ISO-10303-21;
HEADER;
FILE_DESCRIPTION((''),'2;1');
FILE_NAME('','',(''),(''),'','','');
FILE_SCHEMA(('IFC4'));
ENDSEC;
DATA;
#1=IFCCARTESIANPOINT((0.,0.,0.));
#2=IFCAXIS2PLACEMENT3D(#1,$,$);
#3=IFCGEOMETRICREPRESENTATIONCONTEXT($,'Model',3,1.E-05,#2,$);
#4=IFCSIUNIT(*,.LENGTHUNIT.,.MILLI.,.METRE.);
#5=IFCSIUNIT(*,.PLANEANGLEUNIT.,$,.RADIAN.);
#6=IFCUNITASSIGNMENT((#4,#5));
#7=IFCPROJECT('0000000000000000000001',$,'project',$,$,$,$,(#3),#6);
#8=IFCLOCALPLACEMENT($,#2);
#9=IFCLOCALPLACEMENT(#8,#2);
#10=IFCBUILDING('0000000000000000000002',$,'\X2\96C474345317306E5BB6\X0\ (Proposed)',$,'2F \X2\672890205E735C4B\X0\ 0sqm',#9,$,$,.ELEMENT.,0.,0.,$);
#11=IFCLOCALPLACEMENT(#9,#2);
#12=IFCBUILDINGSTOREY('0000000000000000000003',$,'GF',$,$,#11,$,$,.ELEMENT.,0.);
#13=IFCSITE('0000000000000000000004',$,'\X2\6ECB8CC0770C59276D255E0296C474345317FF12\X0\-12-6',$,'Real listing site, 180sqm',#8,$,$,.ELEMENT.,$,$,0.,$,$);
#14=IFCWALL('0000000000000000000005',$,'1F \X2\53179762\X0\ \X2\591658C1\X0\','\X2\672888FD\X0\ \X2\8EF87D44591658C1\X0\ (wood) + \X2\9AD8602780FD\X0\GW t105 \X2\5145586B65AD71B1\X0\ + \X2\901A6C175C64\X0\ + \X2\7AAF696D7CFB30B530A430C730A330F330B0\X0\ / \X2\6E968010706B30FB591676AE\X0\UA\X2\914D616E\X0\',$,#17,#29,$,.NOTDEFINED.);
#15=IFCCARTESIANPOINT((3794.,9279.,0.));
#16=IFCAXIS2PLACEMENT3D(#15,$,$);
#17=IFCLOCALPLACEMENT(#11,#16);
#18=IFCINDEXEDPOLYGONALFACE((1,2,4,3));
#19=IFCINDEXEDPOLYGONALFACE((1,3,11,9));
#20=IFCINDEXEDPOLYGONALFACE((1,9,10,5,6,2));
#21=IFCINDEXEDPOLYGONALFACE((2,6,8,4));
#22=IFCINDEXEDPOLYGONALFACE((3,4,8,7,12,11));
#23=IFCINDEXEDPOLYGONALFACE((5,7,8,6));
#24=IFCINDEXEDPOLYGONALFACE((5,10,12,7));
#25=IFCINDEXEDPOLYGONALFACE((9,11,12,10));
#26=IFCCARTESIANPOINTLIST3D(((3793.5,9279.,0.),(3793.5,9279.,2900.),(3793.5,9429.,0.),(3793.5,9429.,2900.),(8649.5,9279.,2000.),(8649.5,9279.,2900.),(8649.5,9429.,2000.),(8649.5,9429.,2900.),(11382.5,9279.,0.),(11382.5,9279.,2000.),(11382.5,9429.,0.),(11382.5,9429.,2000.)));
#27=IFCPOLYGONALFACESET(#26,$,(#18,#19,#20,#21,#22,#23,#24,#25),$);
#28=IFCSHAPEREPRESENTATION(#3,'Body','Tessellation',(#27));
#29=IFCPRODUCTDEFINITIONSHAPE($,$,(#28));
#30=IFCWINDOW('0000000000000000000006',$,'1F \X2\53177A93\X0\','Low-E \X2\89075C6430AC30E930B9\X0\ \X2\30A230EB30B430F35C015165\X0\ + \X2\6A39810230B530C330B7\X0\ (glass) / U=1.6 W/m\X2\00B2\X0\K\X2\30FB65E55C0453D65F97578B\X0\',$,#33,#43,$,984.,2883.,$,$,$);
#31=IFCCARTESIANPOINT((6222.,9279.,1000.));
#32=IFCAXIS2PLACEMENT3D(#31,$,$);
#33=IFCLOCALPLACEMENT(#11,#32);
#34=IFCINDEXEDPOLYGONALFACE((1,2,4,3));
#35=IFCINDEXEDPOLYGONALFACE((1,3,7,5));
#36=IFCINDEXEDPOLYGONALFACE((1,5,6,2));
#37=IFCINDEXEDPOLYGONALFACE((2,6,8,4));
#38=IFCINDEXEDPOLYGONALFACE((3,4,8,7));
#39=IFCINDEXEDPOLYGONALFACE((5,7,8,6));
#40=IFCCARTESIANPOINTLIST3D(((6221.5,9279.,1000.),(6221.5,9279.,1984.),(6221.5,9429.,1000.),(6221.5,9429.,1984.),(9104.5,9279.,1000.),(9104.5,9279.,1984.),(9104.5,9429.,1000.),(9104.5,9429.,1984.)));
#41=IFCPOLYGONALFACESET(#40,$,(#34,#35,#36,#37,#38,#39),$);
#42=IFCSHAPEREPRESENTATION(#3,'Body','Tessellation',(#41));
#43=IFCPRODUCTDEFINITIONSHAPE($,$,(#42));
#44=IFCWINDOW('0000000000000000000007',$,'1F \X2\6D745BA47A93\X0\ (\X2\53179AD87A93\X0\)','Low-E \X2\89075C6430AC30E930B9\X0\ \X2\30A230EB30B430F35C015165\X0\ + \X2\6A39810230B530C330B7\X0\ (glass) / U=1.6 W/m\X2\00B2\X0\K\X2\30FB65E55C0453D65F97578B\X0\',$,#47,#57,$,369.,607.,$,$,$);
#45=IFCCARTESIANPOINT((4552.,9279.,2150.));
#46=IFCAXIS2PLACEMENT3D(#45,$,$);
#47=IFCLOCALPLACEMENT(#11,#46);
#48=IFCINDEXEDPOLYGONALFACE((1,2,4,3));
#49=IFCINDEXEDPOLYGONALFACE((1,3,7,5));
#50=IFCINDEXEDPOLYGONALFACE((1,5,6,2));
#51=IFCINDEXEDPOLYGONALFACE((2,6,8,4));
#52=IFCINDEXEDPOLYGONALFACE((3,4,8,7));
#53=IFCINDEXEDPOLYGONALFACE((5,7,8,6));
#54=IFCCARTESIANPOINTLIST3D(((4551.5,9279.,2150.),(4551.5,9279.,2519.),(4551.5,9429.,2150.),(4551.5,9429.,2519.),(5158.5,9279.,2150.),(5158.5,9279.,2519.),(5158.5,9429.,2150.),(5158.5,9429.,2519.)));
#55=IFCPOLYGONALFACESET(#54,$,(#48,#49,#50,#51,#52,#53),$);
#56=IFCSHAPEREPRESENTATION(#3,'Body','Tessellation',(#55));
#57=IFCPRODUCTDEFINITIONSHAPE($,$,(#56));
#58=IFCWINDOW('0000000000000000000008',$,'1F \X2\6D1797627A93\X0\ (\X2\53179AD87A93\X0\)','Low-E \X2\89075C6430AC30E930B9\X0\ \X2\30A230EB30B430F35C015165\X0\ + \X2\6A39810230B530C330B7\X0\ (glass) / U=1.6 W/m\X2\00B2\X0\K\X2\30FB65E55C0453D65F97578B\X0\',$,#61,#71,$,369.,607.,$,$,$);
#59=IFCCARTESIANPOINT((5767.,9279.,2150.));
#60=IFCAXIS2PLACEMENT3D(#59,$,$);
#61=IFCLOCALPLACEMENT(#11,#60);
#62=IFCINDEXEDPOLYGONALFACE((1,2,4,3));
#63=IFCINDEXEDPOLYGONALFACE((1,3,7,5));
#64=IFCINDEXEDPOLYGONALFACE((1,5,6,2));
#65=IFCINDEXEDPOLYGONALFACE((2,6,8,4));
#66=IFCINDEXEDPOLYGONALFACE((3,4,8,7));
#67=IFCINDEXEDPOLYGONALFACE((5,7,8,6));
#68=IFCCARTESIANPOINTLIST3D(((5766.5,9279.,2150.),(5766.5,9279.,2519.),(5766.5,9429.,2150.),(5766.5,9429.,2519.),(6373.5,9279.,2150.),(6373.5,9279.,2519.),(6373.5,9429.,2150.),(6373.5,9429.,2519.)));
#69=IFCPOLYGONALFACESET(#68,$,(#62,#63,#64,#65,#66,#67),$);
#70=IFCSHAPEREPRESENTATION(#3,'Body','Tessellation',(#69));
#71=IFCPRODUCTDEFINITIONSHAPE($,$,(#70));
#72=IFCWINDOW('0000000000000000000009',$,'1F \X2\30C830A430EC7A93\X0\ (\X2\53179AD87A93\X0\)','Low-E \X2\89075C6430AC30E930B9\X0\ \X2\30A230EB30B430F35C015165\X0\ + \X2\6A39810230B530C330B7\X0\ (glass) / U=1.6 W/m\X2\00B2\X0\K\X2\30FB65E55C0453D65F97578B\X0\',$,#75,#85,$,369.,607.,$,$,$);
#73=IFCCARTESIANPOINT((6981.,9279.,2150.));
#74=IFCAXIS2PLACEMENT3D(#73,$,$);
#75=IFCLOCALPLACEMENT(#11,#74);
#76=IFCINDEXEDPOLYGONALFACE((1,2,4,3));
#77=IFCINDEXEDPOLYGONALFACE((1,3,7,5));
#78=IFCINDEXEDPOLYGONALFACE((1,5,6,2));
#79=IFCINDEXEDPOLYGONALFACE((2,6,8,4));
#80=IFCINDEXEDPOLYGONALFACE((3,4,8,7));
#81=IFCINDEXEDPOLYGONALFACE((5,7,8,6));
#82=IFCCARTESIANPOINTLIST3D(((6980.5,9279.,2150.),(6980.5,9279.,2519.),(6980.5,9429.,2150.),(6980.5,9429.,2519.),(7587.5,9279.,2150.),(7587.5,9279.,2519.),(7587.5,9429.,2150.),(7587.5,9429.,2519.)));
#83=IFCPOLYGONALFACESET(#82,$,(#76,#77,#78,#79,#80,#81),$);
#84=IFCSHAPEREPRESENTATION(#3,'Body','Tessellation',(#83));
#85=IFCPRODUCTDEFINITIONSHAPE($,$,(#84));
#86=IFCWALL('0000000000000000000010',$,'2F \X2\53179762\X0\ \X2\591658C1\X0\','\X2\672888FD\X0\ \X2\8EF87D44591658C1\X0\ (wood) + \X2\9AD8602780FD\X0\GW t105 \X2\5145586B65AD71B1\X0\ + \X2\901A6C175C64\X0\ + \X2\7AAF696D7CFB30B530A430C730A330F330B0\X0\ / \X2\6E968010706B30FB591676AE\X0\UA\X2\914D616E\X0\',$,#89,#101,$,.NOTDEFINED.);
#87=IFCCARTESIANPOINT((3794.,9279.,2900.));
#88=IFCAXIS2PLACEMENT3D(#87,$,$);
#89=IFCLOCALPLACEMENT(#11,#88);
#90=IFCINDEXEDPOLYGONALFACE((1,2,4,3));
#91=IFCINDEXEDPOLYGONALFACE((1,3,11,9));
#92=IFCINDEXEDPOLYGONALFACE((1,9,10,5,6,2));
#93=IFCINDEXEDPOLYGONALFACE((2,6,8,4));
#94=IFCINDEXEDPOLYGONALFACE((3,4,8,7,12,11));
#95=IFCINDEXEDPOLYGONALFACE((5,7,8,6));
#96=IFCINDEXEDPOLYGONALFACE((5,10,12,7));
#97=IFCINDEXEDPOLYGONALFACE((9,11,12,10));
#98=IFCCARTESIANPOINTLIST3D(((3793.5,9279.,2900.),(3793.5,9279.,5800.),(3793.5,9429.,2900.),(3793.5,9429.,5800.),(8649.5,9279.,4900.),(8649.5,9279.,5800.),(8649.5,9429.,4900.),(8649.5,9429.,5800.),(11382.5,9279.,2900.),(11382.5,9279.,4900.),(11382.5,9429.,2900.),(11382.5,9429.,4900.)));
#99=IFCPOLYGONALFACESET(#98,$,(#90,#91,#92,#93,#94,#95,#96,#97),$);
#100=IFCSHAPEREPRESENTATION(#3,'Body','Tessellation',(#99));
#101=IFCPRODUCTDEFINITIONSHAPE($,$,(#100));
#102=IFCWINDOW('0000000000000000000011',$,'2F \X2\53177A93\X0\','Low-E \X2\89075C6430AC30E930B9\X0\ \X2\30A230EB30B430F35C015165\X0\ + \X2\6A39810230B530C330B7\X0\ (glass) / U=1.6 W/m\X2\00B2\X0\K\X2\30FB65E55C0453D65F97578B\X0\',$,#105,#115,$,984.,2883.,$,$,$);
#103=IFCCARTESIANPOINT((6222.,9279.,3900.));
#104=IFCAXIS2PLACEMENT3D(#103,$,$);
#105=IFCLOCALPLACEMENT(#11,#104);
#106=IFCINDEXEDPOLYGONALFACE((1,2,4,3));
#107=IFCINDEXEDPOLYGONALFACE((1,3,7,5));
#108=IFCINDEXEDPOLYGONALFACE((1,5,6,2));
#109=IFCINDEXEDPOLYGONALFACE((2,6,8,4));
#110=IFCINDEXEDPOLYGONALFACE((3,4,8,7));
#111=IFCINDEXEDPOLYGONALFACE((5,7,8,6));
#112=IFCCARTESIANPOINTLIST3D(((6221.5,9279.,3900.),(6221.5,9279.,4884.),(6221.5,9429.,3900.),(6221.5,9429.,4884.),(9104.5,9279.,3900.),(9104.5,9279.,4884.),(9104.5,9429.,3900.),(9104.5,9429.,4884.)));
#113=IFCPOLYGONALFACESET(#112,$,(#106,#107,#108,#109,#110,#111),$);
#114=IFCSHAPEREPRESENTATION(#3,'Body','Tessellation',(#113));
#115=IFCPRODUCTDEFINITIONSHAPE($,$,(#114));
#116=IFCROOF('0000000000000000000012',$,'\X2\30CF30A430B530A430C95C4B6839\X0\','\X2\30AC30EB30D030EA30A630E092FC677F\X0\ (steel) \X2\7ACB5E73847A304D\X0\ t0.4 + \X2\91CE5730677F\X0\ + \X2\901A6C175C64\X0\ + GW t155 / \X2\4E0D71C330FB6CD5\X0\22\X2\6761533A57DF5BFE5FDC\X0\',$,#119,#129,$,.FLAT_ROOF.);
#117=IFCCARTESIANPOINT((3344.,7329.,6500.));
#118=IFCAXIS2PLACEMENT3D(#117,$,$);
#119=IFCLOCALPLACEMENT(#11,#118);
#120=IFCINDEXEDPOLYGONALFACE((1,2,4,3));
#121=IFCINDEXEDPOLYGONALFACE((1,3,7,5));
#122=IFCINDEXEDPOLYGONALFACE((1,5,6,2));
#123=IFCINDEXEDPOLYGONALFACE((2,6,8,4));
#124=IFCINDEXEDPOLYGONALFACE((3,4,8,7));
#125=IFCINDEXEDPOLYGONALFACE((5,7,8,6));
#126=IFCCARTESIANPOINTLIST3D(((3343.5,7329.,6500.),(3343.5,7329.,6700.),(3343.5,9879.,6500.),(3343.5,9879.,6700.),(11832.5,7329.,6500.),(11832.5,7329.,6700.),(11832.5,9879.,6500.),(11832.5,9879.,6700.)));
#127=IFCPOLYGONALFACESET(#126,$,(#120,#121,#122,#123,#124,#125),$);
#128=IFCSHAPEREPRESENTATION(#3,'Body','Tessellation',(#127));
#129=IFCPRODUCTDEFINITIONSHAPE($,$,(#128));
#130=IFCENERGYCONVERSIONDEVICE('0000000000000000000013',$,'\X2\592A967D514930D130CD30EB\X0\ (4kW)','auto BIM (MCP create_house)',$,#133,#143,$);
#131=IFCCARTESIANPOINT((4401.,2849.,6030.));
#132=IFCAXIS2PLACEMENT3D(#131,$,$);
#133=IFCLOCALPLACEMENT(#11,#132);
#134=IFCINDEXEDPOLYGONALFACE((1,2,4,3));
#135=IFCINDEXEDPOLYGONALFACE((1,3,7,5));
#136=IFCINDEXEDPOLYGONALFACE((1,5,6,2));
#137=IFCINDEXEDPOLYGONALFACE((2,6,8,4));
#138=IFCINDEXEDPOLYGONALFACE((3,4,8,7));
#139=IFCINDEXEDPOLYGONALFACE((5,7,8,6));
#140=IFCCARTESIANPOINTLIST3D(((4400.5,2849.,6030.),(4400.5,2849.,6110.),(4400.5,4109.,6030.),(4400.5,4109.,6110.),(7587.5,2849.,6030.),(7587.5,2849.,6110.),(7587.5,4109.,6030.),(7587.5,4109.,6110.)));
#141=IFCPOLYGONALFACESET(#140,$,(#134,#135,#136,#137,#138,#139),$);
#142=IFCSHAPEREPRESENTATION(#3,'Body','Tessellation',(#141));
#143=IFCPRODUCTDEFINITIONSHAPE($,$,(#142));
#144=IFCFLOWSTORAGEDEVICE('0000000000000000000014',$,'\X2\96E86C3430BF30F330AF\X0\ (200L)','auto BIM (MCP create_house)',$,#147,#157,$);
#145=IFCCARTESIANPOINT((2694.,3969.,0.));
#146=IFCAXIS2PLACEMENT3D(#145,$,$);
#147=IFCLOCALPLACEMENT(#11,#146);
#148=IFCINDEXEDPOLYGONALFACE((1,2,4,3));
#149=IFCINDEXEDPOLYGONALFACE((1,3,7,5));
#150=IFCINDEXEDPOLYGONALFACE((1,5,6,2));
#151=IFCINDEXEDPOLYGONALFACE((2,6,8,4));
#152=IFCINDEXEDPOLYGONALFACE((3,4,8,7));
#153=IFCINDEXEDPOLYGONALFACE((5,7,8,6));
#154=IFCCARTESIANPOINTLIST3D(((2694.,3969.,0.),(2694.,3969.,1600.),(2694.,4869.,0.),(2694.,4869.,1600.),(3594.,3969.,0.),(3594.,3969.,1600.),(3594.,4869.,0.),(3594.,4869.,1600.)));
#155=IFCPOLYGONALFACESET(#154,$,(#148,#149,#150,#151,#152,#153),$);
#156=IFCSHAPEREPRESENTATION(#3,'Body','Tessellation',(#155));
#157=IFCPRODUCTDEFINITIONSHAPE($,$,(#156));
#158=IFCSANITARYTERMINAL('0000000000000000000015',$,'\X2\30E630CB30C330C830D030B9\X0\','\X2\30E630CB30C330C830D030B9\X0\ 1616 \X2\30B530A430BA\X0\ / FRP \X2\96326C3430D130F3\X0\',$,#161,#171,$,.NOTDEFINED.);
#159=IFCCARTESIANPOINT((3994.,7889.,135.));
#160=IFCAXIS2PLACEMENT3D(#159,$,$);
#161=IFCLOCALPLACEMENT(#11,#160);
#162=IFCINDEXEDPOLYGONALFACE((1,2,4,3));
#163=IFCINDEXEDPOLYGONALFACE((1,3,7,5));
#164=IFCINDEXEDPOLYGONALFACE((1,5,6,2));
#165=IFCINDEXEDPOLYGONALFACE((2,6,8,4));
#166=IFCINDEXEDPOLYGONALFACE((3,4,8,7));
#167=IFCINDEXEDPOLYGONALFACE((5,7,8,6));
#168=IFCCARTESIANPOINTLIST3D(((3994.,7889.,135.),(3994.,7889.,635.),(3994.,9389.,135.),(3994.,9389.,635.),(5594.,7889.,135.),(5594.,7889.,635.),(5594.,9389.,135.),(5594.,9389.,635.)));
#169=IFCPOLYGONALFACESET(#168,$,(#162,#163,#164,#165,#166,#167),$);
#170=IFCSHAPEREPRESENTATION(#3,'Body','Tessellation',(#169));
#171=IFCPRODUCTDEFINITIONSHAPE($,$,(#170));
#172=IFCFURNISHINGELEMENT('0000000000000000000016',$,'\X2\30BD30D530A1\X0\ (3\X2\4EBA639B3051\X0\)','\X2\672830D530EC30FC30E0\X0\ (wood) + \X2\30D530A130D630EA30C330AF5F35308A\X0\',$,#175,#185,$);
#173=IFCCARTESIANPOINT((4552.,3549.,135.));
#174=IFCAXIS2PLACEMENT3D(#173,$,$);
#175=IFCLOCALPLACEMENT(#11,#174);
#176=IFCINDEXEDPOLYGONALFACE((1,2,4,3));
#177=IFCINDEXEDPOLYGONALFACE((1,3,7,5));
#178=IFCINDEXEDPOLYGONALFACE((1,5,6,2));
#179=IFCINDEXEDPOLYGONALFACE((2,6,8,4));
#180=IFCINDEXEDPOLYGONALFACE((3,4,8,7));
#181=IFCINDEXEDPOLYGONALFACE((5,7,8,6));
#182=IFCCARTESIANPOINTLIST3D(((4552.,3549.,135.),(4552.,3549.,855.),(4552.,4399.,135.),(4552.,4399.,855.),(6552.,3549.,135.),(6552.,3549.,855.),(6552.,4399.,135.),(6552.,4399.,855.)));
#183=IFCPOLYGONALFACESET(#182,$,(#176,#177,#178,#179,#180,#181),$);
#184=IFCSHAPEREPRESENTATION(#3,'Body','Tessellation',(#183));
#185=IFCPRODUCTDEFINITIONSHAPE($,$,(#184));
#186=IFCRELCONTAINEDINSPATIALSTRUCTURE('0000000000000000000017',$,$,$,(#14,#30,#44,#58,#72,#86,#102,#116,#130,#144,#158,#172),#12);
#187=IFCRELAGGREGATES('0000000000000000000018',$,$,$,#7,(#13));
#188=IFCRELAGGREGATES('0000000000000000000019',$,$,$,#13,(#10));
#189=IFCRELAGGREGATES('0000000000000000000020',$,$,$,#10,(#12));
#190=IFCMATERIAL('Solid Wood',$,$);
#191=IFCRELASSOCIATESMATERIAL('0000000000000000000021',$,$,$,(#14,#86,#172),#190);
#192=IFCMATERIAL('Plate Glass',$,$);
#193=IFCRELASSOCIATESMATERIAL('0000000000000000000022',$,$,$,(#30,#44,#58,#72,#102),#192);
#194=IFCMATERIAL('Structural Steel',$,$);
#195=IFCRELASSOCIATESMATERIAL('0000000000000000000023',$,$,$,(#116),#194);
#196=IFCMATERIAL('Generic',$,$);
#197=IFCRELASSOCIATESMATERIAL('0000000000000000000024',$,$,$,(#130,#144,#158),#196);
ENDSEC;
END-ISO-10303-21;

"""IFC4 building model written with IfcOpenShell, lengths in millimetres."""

from ifc_helpers import new_model, si_unit, frame, frame_2d, origin, place, context, project, spatial, rectangle, extrude, material, element, fill, save


model = new_model("IFC4")

# Units and contexts
model_context = context("Model", 3, precision=1e-05, world=origin())
ifc_project = project(units=[si_unit("LENGTHUNIT", "METRE", prefix="MILLI"), si_unit("PLANEANGLEUNIT", "RADIAN")], contexts=[model_context])

# Site, building, storey
site_placement = place(None, origin())
site = spatial("IfcSite", under=ifc_project, at=site_placement, Name="滋賀県大津市雄琴北２-12-6", ObjectType="Real listing site, 180sqm", CompositionType="ELEMENT", RefElevation=0.0)
building_placement = place(site_placement, origin())
building = spatial("IfcBuilding", under=site, at=building_placement, Name="雄琴北の家 (Proposed)", ObjectType="2F 木造平屋 0sqm", CompositionType="ELEMENT", ElevationOfRefHeight=0.0, ElevationOfTerrain=0.0)
storey_placement = place(building_placement, origin())
storey = spatial("IfcBuildingStorey", under=building, at=storey_placement, Name="GF", CompositionType="ELEMENT", Elevation=0.0)

# Wall, openings, windows
ifc_material_1 = material(Name="Solid Wood")
wall_1_placement = place(storey_placement, frame((3794.0, 9279.0, 0.0)))
wall_1 = element("IfcWall", 1, at=wall_1_placement, inside=storey, material=ifc_material_1, Name="1F 北面 外壁", Description="木製 軸組外壁 (wood) + 高性能GW t105 充填断熱 + 通気層 + 窯業系サイディング / 準耐火・外皮UA配慮", PredefinedType="NOTDEFINED", context=model_context, shape_type="SweptSolid", body=[
    extrude(rectangle(XDim=7589.0, YDim=150.0, at=frame_2d((3794.0, 75.0))), frame((3794.0, 9279.0, 0.0)), (0.0, 0.0, 1.0), 2900.0),
])
opening_1_placement = place(storey_placement, frame((6222.0, 9279.0, 1000.0)))
opening_1 = element("IfcOpeningElement", 2, at=opening_1_placement, cuts=wall_1, PredefinedType="NOTDEFINED", context=model_context, shape_type="SweptSolid", body=[
    extrude(rectangle(XDim=2883.0, YDim=150.0, at=frame_2d((1441.0, 75.0))), frame((6222.0, 9279.0, 1000.0)), (0.0, 0.0, 1.0), 984.0),
])
opening_2_placement = place(storey_placement, frame((4552.0, 9279.0, 2150.0)))
opening_2 = element("IfcOpeningElement", 3, at=opening_2_placement, cuts=wall_1, PredefinedType="NOTDEFINED", context=model_context, shape_type="SweptSolid", body=[
    extrude(rectangle(XDim=607.0, YDim=150.0, at=frame_2d((303.0, 75.0))), frame((4552.0, 9279.0, 2150.0)), (0.0, 0.0, 1.0), 369.0),
])
opening_3_placement = place(storey_placement, frame((5767.0, 9279.0, 2150.0)))
opening_3 = element("IfcOpeningElement", 4, at=opening_3_placement, cuts=wall_1, PredefinedType="NOTDEFINED", context=model_context, shape_type="SweptSolid", body=[
    extrude(rectangle(XDim=607.0, YDim=150.0, at=frame_2d((303.0, 75.0))), frame((5767.0, 9279.0, 2150.0)), (0.0, 0.0, 1.0), 369.0),
])
opening_4_placement = place(storey_placement, frame((6981.0, 9279.0, 2150.0)))
opening_4 = element("IfcOpeningElement", 5, at=opening_4_placement, cuts=wall_1, PredefinedType="NOTDEFINED", context=model_context, shape_type="SweptSolid", body=[
    extrude(rectangle(XDim=607.0, YDim=150.0, at=frame_2d((303.0, 75.0))), frame((6981.0, 9279.0, 2150.0)), (0.0, 0.0, 1.0), 369.0),
])
ifc_material_2 = material(Name="Plate Glass")
window_1_placement = place(storey_placement, frame((6222.0, 9279.0, 1000.0)))
window_1 = element("IfcWindow", 6, at=window_1_placement, inside=storey, material=ifc_material_2, Name="1F 北窓", Description="Low-E 複層ガラス アルゴン封入 + 樹脂サッシ (glass) / U=1.6 W/m²K・日射取得型", OverallHeight=984.0, OverallWidth=2883.0, context=model_context, shape_type="SweptSolid", body=[
    extrude(rectangle(XDim=2883.0, YDim=150.0, at=frame_2d((1441.0, 75.0))), frame((6222.0, 9279.0, 1000.0)), (0.0, 0.0, 1.0), 984.0),
])
fill(opening_1, window_1)
window_2_placement = place(storey_placement, frame((4552.0, 9279.0, 2150.0)))
window_2 = element("IfcWindow", 7, at=window_2_placement, inside=storey, material=ifc_material_2, Name="1F 浴室窓 (北高窓)", Description="Low-E 複層ガラス アルゴン封入 + 樹脂サッシ (glass) / U=1.6 W/m²K・日射取得型", OverallHeight=369.0, OverallWidth=607.0, context=model_context, shape_type="SweptSolid", body=[
    extrude(rectangle(XDim=607.0, YDim=150.0, at=frame_2d((303.0, 75.0))), frame((4552.0, 9279.0, 2150.0)), (0.0, 0.0, 1.0), 369.0),
])
fill(opening_2, window_2)
window_3_placement = place(storey_placement, frame((5767.0, 9279.0, 2150.0)))
window_3 = element("IfcWindow", 8, at=window_3_placement, inside=storey, material=ifc_material_2, Name="1F 洗面窓 (北高窓)", Description="Low-E 複層ガラス アルゴン封入 + 樹脂サッシ (glass) / U=1.6 W/m²K・日射取得型", OverallHeight=369.0, OverallWidth=607.0, context=model_context, shape_type="SweptSolid", body=[
    extrude(rectangle(XDim=607.0, YDim=150.0, at=frame_2d((303.0, 75.0))), frame((5767.0, 9279.0, 2150.0)), (0.0, 0.0, 1.0), 369.0),
])
fill(opening_3, window_3)
window_4_placement = place(storey_placement, frame((6981.0, 9279.0, 2150.0)))
window_4 = element("IfcWindow", 9, at=window_4_placement, inside=storey, material=ifc_material_2, Name="1F トイレ窓 (北高窓)", Description="Low-E 複層ガラス アルゴン封入 + 樹脂サッシ (glass) / U=1.6 W/m²K・日射取得型", OverallHeight=369.0, OverallWidth=607.0, context=model_context, shape_type="SweptSolid", body=[
    extrude(rectangle(XDim=607.0, YDim=150.0, at=frame_2d((303.0, 75.0))), frame((6981.0, 9279.0, 2150.0)), (0.0, 0.0, 1.0), 369.0),
])
fill(opening_4, window_4)

# Wall, opening, window
wall_2_placement = place(storey_placement, frame((3794.0, 9279.0, 2900.0)))
wall_2 = element("IfcWall", 10, at=wall_2_placement, inside=storey, material=ifc_material_1, Name="2F 北面 外壁", Description="木製 軸組外壁 (wood) + 高性能GW t105 充填断熱 + 通気層 + 窯業系サイディング / 準耐火・外皮UA配慮", PredefinedType="NOTDEFINED", context=model_context, shape_type="SweptSolid", body=[
    extrude(rectangle(XDim=7589.0, YDim=150.0, at=frame_2d((3794.0, 75.0))), frame((3794.0, 9279.0, 2900.0)), (0.0, 0.0, 1.0), 2900.0),
])
opening_5_placement = place(storey_placement, frame((6222.0, 9279.0, 3900.0)))
opening_5 = element("IfcOpeningElement", 11, at=opening_5_placement, cuts=wall_2, PredefinedType="NOTDEFINED", context=model_context, shape_type="SweptSolid", body=[
    extrude(rectangle(XDim=2883.0, YDim=150.0, at=frame_2d((1441.0, 75.0))), frame((6222.0, 9279.0, 3900.0)), (0.0, 0.0, 1.0), 984.0),
])
window_5_placement = place(storey_placement, frame((6222.0, 9279.0, 3900.0)))
window_5 = element("IfcWindow", 12, at=window_5_placement, inside=storey, material=ifc_material_2, Name="2F 北窓", Description="Low-E 複層ガラス アルゴン封入 + 樹脂サッシ (glass) / U=1.6 W/m²K・日射取得型", OverallHeight=984.0, OverallWidth=2883.0, context=model_context, shape_type="SweptSolid", body=[
    extrude(rectangle(XDim=2883.0, YDim=150.0, at=frame_2d((1441.0, 75.0))), frame((6222.0, 9279.0, 3900.0)), (0.0, 0.0, 1.0), 984.0),
])
fill(opening_5, window_5)

# Roof
ifc_material_3 = material(Name="Structural Steel")
roof_placement = place(storey_placement, frame((3344.0, 7329.0, 6500.0)))
element("IfcRoof", 13, at=roof_placement, inside=storey, material=ifc_material_3, Name="ハイサイド屋根", Description="ガルバリウム鋼板 (steel) 立平葺き t0.4 + 野地板 + 通気層 + GW t155 / 不燃・法22条区域対応", PredefinedType="FLAT_ROOF", context=model_context, shape_type="SweptSolid", body=[
    extrude(rectangle(XDim=8489.0, YDim=2550.0, at=frame_2d((4244.0, 1275.0))), frame((3344.0, 7329.0, 6500.0)), (0.0, 0.0, 1.0), 200.0),
])

# Energy conversion device
ifc_material_4 = material(Name="Generic")
energy_conversion_device_placement = place(storey_placement, frame((4401.0, 2849.0, 6030.0)))
element("IfcEnergyConversionDevice", 14, at=energy_conversion_device_placement, inside=storey, material=ifc_material_4, Name="太陽光パネル (4kW)", Description="auto BIM (MCP create_house)", context=model_context, shape_type="SweptSolid", body=[
    extrude(rectangle(XDim=3187.0, YDim=1260.0, at=frame_2d((1593.0, 630.0))), frame((4401.0, 2849.0, 6030.0)), (0.0, 0.0, 1.0), 80.0),
])

# Flow storage device
flow_storage_device_placement = place(storey_placement, frame((2694.0, 3969.0, 0.0)))
element("IfcFlowStorageDevice", 15, at=flow_storage_device_placement, inside=storey, material=ifc_material_4, Name="雨水タンク (200L)", Description="auto BIM (MCP create_house)", context=model_context, shape_type="SweptSolid", body=[
    extrude(rectangle(XDim=900.0, YDim=900.0, at=frame_2d((450.0, 450.0))), frame((2694.0, 3969.0, 0.0)), (0.0, 0.0, 1.0), 1600.0),
])

# Sanitary terminal
sanitary_terminal_placement = place(storey_placement, frame((3994.0, 7889.0, 135.0)))
element("IfcSanitaryTerminal", 16, at=sanitary_terminal_placement, inside=storey, material=ifc_material_4, Name="ユニットバス", Description="ユニットバス 1616 サイズ / FRP 防水パン", PredefinedType="NOTDEFINED", context=model_context, shape_type="SweptSolid", body=[
    extrude(rectangle(XDim=1600.0, YDim=1500.0, at=frame_2d((800.0, 750.0))), frame((3994.0, 7889.0, 135.0)), (0.0, 0.0, 1.0), 500.0),
])

# Furnishing element
furnishing_1_placement = place(storey_placement, frame((4552.0, 3549.0, 135.0)))
element("IfcFurnishingElement", 17, at=furnishing_1_placement, inside=storey, material=ifc_material_1, Name="ソファ (3人掛け)", Description="木フレーム (wood) + ファブリック張り", context=model_context, shape_type="SweptSolid", body=[
    extrude(rectangle(XDim=2000.0, YDim=850.0, at=frame_2d((1000.0, 425.0))), frame((4552.0, 3549.0, 135.0)), (0.0, 0.0, 1.0), 720.0),
])

save(model, "model.ifc")
